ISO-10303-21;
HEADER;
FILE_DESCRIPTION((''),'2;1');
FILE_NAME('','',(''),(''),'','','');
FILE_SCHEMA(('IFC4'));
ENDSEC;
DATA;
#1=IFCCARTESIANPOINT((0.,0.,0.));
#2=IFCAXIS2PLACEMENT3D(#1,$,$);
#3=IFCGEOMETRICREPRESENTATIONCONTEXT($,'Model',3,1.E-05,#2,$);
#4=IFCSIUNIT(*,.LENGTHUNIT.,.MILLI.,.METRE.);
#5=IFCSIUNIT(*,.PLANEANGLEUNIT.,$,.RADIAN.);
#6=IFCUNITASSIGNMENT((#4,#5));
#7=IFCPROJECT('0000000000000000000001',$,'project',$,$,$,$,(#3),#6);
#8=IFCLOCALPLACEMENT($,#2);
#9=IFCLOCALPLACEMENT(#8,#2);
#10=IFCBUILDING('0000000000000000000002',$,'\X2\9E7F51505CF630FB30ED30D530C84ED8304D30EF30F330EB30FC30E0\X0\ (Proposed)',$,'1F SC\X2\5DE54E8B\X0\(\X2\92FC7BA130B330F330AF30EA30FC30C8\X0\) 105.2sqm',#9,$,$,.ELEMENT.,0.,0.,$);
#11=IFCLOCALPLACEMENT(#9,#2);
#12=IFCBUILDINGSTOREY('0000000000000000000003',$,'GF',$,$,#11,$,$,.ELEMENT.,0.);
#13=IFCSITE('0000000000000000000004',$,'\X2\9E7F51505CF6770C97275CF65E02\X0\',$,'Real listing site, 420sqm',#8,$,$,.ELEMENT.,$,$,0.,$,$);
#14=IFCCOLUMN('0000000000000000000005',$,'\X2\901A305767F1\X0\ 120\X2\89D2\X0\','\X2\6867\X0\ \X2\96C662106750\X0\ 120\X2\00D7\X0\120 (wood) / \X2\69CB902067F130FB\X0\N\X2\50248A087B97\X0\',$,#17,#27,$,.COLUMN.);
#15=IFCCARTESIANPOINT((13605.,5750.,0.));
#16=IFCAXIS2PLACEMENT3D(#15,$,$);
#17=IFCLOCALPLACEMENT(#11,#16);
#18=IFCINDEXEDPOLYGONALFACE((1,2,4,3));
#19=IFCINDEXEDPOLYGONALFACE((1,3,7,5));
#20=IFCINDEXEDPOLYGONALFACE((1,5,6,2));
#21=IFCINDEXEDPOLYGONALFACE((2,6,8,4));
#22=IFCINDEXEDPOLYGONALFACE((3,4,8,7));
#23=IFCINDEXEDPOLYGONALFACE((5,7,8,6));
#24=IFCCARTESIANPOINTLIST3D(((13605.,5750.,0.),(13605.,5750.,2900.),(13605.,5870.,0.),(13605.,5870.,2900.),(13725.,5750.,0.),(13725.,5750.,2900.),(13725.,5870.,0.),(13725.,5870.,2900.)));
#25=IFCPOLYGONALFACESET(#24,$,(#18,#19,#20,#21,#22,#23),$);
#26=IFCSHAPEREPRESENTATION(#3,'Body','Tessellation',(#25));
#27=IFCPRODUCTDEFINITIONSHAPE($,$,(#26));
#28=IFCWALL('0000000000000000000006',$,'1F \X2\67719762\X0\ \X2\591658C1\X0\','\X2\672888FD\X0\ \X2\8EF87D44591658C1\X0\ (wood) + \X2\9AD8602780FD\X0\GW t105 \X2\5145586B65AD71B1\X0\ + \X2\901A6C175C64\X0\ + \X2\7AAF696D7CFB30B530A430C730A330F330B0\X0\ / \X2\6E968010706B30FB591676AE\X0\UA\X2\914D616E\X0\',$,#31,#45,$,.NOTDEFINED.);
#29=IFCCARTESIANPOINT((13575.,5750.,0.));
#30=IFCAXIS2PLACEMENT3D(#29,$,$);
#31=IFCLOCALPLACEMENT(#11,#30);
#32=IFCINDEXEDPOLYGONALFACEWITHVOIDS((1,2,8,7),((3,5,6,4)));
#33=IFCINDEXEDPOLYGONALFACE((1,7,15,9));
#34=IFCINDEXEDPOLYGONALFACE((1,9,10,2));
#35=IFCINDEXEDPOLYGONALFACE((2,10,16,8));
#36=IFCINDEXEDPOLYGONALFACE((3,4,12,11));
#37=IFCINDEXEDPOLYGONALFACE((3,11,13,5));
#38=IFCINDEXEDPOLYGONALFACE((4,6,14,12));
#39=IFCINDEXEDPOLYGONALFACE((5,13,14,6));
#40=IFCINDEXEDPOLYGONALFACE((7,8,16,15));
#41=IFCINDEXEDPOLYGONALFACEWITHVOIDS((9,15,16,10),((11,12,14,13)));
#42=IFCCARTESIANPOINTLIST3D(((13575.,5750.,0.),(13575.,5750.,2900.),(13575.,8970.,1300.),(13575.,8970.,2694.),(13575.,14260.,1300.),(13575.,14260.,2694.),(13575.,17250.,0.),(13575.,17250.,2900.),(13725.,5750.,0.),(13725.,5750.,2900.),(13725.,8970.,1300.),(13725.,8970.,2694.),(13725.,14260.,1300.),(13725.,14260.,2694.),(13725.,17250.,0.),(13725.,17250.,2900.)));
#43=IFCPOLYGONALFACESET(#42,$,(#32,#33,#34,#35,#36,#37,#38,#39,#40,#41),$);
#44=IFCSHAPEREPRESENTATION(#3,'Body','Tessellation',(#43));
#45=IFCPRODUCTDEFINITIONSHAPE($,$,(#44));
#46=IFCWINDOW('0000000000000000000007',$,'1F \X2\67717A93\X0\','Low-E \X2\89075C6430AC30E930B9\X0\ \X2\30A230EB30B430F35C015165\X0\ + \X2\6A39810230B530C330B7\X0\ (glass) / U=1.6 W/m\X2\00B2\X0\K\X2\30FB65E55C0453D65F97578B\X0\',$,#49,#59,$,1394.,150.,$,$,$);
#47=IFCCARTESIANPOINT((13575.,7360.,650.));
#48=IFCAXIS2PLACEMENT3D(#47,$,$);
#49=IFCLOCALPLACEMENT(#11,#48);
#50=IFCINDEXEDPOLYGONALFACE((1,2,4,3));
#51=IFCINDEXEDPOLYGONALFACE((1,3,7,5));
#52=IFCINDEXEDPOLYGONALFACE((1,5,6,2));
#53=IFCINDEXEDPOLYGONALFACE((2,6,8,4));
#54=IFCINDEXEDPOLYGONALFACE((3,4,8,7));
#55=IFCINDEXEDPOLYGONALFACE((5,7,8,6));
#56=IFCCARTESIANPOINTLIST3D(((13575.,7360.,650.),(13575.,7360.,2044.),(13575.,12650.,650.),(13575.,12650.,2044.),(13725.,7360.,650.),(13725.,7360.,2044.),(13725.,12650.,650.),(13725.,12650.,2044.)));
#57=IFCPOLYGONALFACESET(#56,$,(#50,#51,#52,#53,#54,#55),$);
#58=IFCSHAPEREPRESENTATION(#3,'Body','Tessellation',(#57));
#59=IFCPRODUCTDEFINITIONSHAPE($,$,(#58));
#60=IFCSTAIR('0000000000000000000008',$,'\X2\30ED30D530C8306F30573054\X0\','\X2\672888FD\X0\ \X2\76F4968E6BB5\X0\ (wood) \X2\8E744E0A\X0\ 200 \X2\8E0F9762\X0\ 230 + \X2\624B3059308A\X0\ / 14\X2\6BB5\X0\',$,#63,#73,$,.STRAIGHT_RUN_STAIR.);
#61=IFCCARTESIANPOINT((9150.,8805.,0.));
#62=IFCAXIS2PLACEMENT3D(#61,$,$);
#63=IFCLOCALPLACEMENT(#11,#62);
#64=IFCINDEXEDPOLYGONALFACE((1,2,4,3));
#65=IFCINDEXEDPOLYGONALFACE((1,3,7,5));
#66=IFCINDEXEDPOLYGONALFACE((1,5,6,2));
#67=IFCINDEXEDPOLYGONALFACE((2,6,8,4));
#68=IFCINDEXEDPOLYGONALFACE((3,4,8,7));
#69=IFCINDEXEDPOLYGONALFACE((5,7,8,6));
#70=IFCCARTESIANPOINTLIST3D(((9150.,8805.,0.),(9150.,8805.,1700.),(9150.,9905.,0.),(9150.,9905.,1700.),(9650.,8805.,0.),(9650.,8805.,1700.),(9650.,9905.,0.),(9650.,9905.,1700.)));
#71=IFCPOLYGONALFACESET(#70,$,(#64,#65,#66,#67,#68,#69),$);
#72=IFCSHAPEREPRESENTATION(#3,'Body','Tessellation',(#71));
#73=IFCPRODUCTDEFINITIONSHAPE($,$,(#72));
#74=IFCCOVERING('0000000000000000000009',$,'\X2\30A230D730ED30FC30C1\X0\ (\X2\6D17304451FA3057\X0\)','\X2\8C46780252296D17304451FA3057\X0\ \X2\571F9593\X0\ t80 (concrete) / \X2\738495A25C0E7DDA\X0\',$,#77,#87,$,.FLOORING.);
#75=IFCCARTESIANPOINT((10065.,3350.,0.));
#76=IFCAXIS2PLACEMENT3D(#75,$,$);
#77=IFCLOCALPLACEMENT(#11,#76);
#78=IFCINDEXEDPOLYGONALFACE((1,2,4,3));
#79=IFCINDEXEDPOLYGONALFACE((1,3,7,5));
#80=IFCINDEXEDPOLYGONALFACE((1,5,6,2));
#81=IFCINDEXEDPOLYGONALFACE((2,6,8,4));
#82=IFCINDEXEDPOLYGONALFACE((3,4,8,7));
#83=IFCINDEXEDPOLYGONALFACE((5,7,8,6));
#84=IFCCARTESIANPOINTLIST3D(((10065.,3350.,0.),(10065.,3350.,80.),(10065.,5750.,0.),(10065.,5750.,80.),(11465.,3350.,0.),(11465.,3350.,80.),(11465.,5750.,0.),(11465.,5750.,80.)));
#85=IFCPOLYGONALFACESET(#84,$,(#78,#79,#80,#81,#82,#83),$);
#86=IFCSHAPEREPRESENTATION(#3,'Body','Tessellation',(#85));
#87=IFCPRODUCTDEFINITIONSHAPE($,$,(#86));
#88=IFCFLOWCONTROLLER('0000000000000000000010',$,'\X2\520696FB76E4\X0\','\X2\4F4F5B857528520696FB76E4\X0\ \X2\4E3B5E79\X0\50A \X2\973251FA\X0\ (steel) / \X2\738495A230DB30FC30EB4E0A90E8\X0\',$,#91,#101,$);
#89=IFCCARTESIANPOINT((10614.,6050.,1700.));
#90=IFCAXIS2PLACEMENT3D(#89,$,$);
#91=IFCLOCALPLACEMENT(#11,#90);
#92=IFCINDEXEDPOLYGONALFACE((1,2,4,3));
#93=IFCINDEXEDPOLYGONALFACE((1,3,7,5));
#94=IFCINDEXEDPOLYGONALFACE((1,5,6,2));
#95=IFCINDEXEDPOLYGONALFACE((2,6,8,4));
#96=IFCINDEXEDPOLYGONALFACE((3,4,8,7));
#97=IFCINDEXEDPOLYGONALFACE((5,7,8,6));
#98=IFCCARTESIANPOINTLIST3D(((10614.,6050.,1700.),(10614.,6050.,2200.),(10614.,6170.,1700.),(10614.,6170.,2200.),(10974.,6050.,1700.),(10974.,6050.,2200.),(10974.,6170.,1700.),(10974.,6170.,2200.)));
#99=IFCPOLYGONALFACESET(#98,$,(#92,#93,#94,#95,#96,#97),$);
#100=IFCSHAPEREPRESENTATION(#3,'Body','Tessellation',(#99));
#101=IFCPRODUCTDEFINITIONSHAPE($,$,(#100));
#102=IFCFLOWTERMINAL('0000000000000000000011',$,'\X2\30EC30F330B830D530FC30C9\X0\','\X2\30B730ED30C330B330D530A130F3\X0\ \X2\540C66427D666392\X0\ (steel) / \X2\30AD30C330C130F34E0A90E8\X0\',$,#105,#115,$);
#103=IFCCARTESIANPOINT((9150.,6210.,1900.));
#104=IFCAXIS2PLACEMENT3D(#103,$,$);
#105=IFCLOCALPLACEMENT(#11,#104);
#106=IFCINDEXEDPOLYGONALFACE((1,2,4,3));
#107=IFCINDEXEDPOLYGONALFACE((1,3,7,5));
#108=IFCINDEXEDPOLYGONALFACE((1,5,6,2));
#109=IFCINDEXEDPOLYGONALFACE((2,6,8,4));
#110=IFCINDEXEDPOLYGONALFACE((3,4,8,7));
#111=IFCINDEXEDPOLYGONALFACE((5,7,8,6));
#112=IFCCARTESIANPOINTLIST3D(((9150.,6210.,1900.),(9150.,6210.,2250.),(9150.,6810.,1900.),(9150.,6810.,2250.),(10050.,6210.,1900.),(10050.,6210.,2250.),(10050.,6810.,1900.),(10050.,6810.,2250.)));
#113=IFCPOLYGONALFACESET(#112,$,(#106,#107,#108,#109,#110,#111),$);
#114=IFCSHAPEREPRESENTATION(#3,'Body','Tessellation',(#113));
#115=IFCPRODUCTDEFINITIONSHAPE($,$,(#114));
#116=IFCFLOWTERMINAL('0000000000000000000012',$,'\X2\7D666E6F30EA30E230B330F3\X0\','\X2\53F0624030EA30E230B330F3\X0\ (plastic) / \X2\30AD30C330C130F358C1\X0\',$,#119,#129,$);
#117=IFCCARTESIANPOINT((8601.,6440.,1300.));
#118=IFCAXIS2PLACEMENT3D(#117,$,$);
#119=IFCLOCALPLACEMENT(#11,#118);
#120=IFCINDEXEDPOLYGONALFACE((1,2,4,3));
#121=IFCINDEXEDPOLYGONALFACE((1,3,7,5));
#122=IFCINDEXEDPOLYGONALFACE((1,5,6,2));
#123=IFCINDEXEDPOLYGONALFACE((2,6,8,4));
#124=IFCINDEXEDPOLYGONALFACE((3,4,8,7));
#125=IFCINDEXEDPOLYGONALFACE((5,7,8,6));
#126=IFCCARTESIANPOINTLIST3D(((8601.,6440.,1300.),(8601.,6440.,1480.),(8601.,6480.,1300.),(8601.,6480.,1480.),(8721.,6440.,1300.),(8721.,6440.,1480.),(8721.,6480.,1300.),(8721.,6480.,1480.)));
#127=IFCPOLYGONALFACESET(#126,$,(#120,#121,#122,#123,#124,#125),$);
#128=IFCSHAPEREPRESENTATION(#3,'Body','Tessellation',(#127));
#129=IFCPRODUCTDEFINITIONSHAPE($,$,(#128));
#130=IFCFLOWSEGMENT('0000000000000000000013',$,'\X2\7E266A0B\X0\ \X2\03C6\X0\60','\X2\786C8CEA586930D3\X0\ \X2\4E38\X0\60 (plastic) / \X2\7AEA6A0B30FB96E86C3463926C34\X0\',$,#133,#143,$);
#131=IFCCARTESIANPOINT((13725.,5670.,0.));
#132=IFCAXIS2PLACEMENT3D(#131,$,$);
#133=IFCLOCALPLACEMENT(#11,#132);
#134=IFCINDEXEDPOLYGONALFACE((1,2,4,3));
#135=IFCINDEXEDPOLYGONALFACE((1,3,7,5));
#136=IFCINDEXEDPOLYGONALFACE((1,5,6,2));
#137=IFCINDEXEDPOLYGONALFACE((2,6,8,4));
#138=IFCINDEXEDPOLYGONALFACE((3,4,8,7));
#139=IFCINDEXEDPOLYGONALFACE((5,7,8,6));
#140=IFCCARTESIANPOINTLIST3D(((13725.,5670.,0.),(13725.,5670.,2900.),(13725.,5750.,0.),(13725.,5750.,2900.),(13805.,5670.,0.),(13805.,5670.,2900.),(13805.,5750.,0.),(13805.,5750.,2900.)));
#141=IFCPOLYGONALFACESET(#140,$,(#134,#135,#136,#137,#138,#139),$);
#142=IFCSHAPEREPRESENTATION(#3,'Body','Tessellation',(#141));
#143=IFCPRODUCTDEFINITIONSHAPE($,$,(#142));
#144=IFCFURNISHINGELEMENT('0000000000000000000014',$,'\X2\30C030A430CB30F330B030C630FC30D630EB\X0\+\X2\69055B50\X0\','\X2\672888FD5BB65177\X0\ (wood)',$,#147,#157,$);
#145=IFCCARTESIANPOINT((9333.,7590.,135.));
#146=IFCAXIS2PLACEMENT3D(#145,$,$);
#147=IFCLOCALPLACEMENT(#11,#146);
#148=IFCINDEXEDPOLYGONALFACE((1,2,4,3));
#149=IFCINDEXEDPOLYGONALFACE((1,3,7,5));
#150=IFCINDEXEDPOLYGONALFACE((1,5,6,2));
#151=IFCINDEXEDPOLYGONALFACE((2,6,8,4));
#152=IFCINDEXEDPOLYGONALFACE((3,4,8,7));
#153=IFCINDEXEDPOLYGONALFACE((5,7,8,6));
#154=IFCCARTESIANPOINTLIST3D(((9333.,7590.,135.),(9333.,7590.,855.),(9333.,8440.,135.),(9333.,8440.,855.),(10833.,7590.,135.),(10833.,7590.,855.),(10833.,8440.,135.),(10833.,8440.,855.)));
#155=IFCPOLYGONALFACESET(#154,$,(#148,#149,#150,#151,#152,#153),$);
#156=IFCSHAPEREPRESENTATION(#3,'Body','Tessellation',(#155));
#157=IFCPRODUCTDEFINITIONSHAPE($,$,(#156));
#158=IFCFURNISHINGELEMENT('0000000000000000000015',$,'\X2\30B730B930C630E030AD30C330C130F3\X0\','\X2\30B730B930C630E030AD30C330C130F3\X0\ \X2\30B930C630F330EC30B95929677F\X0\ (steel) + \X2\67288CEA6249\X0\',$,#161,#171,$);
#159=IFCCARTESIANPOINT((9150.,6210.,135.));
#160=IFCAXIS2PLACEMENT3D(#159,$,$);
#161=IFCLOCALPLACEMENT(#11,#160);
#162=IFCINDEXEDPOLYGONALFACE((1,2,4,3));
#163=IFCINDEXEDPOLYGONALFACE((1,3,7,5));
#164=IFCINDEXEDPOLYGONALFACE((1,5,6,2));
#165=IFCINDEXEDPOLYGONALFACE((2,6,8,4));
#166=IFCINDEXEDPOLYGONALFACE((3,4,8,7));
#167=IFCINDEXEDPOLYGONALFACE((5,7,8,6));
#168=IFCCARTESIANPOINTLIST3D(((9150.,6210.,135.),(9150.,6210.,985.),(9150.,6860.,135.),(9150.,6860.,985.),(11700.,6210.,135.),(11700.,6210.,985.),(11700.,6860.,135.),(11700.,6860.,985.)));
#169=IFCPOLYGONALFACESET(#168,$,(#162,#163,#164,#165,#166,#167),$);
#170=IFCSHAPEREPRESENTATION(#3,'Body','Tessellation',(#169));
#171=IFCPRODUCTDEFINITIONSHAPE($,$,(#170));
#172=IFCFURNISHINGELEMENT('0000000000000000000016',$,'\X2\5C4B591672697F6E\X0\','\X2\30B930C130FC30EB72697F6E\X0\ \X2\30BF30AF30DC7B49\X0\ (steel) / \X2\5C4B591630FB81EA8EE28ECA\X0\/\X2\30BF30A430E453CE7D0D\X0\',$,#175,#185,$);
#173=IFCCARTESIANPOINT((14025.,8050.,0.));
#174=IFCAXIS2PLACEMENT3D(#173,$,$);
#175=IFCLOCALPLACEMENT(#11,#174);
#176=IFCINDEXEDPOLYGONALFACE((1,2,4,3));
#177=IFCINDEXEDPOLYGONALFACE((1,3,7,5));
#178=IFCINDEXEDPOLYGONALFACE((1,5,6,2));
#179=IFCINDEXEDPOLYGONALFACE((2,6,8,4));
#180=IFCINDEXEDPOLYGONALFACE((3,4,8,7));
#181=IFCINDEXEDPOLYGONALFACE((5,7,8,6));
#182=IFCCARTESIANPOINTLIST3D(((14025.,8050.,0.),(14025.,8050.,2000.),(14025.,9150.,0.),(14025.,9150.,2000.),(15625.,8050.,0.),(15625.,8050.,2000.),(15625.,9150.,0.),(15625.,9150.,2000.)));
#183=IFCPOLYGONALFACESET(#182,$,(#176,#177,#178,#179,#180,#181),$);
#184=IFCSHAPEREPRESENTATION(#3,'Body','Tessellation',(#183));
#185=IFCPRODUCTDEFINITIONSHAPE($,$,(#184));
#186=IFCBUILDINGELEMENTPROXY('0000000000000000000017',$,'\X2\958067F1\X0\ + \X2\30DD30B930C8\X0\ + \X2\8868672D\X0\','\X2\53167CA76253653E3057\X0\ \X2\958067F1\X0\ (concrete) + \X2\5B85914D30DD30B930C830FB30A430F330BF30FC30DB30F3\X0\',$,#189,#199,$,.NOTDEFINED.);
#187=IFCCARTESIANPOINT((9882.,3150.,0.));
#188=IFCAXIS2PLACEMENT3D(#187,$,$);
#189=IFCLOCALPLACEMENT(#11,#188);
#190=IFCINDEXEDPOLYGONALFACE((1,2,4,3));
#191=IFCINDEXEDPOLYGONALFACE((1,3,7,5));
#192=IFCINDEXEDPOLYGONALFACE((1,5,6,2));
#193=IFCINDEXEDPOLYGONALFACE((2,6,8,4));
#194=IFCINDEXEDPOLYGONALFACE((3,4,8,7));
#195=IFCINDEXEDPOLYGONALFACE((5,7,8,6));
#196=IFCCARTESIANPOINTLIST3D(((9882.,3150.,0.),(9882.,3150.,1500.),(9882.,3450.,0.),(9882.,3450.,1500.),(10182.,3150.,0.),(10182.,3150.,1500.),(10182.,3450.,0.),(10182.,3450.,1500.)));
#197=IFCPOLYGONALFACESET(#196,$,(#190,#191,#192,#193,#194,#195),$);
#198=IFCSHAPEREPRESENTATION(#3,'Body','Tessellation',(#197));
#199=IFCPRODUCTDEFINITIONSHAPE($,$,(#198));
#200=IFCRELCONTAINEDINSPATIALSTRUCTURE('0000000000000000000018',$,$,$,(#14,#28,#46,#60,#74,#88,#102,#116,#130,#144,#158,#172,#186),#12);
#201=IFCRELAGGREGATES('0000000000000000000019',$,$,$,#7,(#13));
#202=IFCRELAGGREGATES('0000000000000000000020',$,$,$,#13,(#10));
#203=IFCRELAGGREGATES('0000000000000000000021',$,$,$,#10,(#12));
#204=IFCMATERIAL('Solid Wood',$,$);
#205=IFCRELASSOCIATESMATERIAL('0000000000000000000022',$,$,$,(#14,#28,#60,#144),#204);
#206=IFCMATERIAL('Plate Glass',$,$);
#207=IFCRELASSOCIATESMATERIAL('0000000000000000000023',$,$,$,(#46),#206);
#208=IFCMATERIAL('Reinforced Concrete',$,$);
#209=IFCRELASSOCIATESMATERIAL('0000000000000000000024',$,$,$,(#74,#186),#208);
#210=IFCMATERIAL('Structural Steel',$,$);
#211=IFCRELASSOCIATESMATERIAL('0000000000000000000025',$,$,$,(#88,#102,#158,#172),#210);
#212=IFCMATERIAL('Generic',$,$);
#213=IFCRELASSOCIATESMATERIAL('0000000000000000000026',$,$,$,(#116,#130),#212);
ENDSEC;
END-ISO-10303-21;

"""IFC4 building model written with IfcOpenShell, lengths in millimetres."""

from ifc_helpers import new_model, si_unit, frame, frame_2d, origin, place, context, project, spatial, rectangle, extrude, material, element, fill, save


model = new_model("IFC4")

# Units and contexts
model_context = context("Model", 3, precision=1e-05, world=origin())
ifc_project = project(units=[si_unit("LENGTHUNIT", "METRE", prefix="MILLI"), si_unit("PLANEANGLEUNIT", "RADIAN")], contexts=[model_context])

# Site, building, storey
site_placement = place(None, origin())
site = spatial("IfcSite", under=ifc_project, at=site_placement, Name="鹿児島県霧島市", ObjectType="Real listing site, 420sqm", CompositionType="ELEMENT", RefElevation=0.0)
building_placement = place(site_placement, origin())
building = spatial("IfcBuilding", under=site, at=building_placement, Name="鹿児島・ロフト付きワンルーム (Proposed)", ObjectType="1F SC工事(鋼管コンクリート) 105.2sqm", CompositionType="ELEMENT", ElevationOfRefHeight=0.0, ElevationOfTerrain=0.0)
storey_placement = place(building_placement, origin())
storey = spatial("IfcBuildingStorey", under=building, at=storey_placement, Name="GF", CompositionType="ELEMENT", Elevation=0.0)

# Column
ifc_material_1 = material(Name="Solid Wood")
column_1_placement = place(storey_placement, frame((13605.0, 5750.0, 0.0)))
element("IfcColumn", 1, at=column_1_placement, inside=storey, material=ifc_material_1, Name="通し柱 120角", Description="桧 集成材 120×120 (wood) / 構造柱・N値計算", PredefinedType="COLUMN", context=model_context, shape_type="SweptSolid", body=[
    extrude(rectangle(XDim=120.0, YDim=120.0, at=frame_2d((60.0, 60.0))), frame((13605.0, 5750.0, 0.0)), (0.0, 0.0, 1.0), 2900.0),
])

# Wall, opening, window
wall_1_placement = place(storey_placement, frame((13575.0, 5750.0, 0.0)))
wall_1 = element("IfcWall", 2, at=wall_1_placement, inside=storey, material=ifc_material_1, Name="1F 東面 外壁", Description="木製 軸組外壁 (wood) + 高性能GW t105 充填断熱 + 通気層 + 窯業系サイディング / 準耐火・外皮UA配慮", PredefinedType="NOTDEFINED", context=model_context, shape_type="SweptSolid", body=[
    extrude(rectangle(XDim=150.0, YDim=11500.0, at=frame_2d((75.0, 5750.0))), frame((13575.0, 5750.0, 0.0)), (0.0, 0.0, 1.0), 2900.0),
])
opening_placement = place(storey_placement, frame((13575.0, 7360.0, 650.0)))
opening = element("IfcOpeningElement", 3, at=opening_placement, cuts=wall_1, PredefinedType="NOTDEFINED", context=model_context, shape_type="SweptSolid", body=[
    extrude(rectangle(XDim=150.0, YDim=5290.0, at=frame_2d((75.0, 2645.0))), frame((13575.0, 7360.0, 650.0)), (0.0, 0.0, 1.0), 1394.0),
])
ifc_material_2 = material(Name="Plate Glass")
window_placement = place(storey_placement, frame((13575.0, 7360.0, 650.0)))
window = element("IfcWindow", 4, at=window_placement, inside=storey, material=ifc_material_2, Name="1F 東窓", Description="Low-E 複層ガラス アルゴン封入 + 樹脂サッシ (glass) / U=1.6 W/m²K・日射取得型", OverallHeight=1394.0, OverallWidth=150.0, context=model_context, shape_type="SweptSolid", body=[
    extrude(rectangle(XDim=150.0, YDim=5290.0, at=frame_2d((75.0, 2645.0))), frame((13575.0, 7360.0, 650.0)), (0.0, 0.0, 1.0), 1394.0),
])
fill(opening, window)

# Stair
stair_placement = place(storey_placement, frame((9150.0, 8805.0, 0.0)))
element("IfcStair", 5, at=stair_placement, inside=storey, material=ifc_material_1, Name="ロフトはしご", Description="木製 直階段 (wood) 蹴上 200 踏面 230 + 手すり / 14段", PredefinedType="STRAIGHT_RUN_STAIR", context=model_context, shape_type="SweptSolid", body=[
    extrude(rectangle(XDim=500.0, YDim=1100.0, at=frame_2d((250.0, 550.0))), frame((9150.0, 8805.0, 0.0)), (0.0, 0.0, 1.0), 1700.0),
])

# Covering
ifc_material_3 = material(Name="Reinforced Concrete")
covering_placement = place(storey_placement, frame((10065.0, 3350.0, 0.0)))
element("IfcCovering", 6, at=covering_placement, inside=storey, material=ifc_material_3, Name="アプローチ (洗い出し)", Description="豆砂利洗い出し 土間 t80 (concrete) / 玄関導線", PredefinedType="FLOORING", context=model_context, shape_type="SweptSolid", body=[
    extrude(rectangle(XDim=1400.0, YDim=2400.0, at=frame_2d((700.0, 1200.0))), frame((10065.0, 3350.0, 0.0)), (0.0, 0.0, 1.0), 80.0),
])

# Flow controller
ifc_material_4 = material(Name="Structural Steel")
flow_controller_placement = place(storey_placement, frame((10614.0, 6050.0, 1700.0)))
element("IfcFlowController", 7, at=flow_controller_placement, inside=storey, material=ifc_material_4, Name="分電盤", Description="住宅用分電盤 主幹50A 露出 (steel) / 玄関ホール上部", context=model_context, shape_type="SweptSolid", body=[
    extrude(rectangle(XDim=360.0, YDim=120.0, at=frame_2d((180.0, 60.0))), frame((10614.0, 6050.0, 1700.0)), (0.0, 0.0, 1.0), 500.0),
])

# Flow terminals
flow_terminal_1_placement = place(storey_placement, frame((9150.0, 6210.0, 1900.0)))
element("IfcFlowTerminal", 8, at=flow_terminal_1_placement, inside=storey, material=ifc_material_4, Name="レンジフード", Description="シロッコファン 同時給排 (steel) / キッチン上部", context=model_context, shape_type="SweptSolid", body=[
    extrude(rectangle(XDim=900.0, YDim=600.0, at=frame_2d((450.0, 300.0))), frame((9150.0, 6210.0, 1900.0)), (0.0, 0.0, 1.0), 350.0),
])
ifc_material_5 = material(Name="Generic")
flow_terminal_2_placement = place(storey_placement, frame((8601.0, 6440.0, 1300.0)))
element("IfcFlowTerminal", 9, at=flow_terminal_2_placement, inside=storey, material=ifc_material_5, Name="給湯リモコン", Description="台所リモコン (plastic) / キッチン壁", context=model_context, shape_type="SweptSolid", body=[
    extrude(rectangle(XDim=120.0, YDim=40.0, at=frame_2d((60.0, 20.0))), frame((8601.0, 6440.0, 1300.0)), (0.0, 0.0, 1.0), 180.0),
])

# Flow segment
flow_segment_placement = place(storey_placement, frame((13725.0, 5670.0, 0.0)))
element("IfcFlowSegment", 10, at=flow_segment_placement, inside=storey, material=ifc_material_5, Name="縦樋 φ60", Description="硬質塩ビ 丸60 (plastic) / 竪樋・雨水排水", context=model_context, shape_type="SweptSolid", body=[
    extrude(rectangle(XDim=80.0, YDim=80.0, at=frame_2d((40.0, 40.0))), frame((13725.0, 5670.0, 0.0)), (0.0, 0.0, 1.0), 2900.0),
])

# Furnishing elements
furnishing_1_placement = place(storey_placement, frame((9333.0, 7590.0, 135.0)))
element("IfcFurnishingElement", 11, at=furnishing_1_placement, inside=storey, material=ifc_material_1, Name="ダイニングテーブル+椅子", Description="木製家具 (wood)", context=model_context, shape_type="SweptSolid", body=[
    extrude(rectangle(XDim=1500.0, YDim=850.0, at=frame_2d((750.0, 425.0))), frame((9333.0, 7590.0, 135.0)), (0.0, 0.0, 1.0), 720.0),
])
furnishing_2_placement = place(storey_placement, frame((9150.0, 6210.0, 135.0)))
element("IfcFurnishingElement", 12, at=furnishing_2_placement, inside=storey, material=ifc_material_4, Name="システムキッチン", Description="システムキッチン ステンレス天板 (steel) + 木質扉", context=model_context, shape_type="SweptSolid", body=[
    extrude(rectangle(XDim=2550.0, YDim=650.0, at=frame_2d((1275.0, 325.0))), frame((9150.0, 6210.0, 135.0)), (0.0, 0.0, 1.0), 850.0),
])
furnishing_3_placement = place(storey_placement, frame((14025.0, 8050.0, 0.0)))
element("IfcFurnishingElement", 13, at=furnishing_3_placement, inside=storey, material=ifc_material_4, Name="屋外物置", Description="スチール物置 タクボ等 (steel) / 屋外・自転車/タイヤ収納", context=model_context, shape_type="SweptSolid", body=[
    extrude(rectangle(XDim=1600.0, YDim=1100.0, at=frame_2d((800.0, 550.0))), frame((14025.0, 8050.0, 0.0)), (0.0, 0.0, 1.0), 2000.0),
])

# Building element proxy
proxy_placement = place(storey_placement, frame((9882.0, 3150.0, 0.0)))
element("IfcBuildingElementProxy", 14, at=proxy_placement, inside=storey, material=ifc_material_3, Name="門柱 + ポスト + 表札", Description="化粧打放し 門柱 (concrete) + 宅配ポスト・インターホン", PredefinedType="NOTDEFINED", context=model_context, shape_type="SweptSolid", body=[
    extrude(rectangle(XDim=300.0, YDim=300.0, at=frame_2d((150.0, 150.0))), frame((9882.0, 3150.0, 0.0)), (0.0, 0.0, 1.0), 1500.0),
])

save(model, "model.ifc")
